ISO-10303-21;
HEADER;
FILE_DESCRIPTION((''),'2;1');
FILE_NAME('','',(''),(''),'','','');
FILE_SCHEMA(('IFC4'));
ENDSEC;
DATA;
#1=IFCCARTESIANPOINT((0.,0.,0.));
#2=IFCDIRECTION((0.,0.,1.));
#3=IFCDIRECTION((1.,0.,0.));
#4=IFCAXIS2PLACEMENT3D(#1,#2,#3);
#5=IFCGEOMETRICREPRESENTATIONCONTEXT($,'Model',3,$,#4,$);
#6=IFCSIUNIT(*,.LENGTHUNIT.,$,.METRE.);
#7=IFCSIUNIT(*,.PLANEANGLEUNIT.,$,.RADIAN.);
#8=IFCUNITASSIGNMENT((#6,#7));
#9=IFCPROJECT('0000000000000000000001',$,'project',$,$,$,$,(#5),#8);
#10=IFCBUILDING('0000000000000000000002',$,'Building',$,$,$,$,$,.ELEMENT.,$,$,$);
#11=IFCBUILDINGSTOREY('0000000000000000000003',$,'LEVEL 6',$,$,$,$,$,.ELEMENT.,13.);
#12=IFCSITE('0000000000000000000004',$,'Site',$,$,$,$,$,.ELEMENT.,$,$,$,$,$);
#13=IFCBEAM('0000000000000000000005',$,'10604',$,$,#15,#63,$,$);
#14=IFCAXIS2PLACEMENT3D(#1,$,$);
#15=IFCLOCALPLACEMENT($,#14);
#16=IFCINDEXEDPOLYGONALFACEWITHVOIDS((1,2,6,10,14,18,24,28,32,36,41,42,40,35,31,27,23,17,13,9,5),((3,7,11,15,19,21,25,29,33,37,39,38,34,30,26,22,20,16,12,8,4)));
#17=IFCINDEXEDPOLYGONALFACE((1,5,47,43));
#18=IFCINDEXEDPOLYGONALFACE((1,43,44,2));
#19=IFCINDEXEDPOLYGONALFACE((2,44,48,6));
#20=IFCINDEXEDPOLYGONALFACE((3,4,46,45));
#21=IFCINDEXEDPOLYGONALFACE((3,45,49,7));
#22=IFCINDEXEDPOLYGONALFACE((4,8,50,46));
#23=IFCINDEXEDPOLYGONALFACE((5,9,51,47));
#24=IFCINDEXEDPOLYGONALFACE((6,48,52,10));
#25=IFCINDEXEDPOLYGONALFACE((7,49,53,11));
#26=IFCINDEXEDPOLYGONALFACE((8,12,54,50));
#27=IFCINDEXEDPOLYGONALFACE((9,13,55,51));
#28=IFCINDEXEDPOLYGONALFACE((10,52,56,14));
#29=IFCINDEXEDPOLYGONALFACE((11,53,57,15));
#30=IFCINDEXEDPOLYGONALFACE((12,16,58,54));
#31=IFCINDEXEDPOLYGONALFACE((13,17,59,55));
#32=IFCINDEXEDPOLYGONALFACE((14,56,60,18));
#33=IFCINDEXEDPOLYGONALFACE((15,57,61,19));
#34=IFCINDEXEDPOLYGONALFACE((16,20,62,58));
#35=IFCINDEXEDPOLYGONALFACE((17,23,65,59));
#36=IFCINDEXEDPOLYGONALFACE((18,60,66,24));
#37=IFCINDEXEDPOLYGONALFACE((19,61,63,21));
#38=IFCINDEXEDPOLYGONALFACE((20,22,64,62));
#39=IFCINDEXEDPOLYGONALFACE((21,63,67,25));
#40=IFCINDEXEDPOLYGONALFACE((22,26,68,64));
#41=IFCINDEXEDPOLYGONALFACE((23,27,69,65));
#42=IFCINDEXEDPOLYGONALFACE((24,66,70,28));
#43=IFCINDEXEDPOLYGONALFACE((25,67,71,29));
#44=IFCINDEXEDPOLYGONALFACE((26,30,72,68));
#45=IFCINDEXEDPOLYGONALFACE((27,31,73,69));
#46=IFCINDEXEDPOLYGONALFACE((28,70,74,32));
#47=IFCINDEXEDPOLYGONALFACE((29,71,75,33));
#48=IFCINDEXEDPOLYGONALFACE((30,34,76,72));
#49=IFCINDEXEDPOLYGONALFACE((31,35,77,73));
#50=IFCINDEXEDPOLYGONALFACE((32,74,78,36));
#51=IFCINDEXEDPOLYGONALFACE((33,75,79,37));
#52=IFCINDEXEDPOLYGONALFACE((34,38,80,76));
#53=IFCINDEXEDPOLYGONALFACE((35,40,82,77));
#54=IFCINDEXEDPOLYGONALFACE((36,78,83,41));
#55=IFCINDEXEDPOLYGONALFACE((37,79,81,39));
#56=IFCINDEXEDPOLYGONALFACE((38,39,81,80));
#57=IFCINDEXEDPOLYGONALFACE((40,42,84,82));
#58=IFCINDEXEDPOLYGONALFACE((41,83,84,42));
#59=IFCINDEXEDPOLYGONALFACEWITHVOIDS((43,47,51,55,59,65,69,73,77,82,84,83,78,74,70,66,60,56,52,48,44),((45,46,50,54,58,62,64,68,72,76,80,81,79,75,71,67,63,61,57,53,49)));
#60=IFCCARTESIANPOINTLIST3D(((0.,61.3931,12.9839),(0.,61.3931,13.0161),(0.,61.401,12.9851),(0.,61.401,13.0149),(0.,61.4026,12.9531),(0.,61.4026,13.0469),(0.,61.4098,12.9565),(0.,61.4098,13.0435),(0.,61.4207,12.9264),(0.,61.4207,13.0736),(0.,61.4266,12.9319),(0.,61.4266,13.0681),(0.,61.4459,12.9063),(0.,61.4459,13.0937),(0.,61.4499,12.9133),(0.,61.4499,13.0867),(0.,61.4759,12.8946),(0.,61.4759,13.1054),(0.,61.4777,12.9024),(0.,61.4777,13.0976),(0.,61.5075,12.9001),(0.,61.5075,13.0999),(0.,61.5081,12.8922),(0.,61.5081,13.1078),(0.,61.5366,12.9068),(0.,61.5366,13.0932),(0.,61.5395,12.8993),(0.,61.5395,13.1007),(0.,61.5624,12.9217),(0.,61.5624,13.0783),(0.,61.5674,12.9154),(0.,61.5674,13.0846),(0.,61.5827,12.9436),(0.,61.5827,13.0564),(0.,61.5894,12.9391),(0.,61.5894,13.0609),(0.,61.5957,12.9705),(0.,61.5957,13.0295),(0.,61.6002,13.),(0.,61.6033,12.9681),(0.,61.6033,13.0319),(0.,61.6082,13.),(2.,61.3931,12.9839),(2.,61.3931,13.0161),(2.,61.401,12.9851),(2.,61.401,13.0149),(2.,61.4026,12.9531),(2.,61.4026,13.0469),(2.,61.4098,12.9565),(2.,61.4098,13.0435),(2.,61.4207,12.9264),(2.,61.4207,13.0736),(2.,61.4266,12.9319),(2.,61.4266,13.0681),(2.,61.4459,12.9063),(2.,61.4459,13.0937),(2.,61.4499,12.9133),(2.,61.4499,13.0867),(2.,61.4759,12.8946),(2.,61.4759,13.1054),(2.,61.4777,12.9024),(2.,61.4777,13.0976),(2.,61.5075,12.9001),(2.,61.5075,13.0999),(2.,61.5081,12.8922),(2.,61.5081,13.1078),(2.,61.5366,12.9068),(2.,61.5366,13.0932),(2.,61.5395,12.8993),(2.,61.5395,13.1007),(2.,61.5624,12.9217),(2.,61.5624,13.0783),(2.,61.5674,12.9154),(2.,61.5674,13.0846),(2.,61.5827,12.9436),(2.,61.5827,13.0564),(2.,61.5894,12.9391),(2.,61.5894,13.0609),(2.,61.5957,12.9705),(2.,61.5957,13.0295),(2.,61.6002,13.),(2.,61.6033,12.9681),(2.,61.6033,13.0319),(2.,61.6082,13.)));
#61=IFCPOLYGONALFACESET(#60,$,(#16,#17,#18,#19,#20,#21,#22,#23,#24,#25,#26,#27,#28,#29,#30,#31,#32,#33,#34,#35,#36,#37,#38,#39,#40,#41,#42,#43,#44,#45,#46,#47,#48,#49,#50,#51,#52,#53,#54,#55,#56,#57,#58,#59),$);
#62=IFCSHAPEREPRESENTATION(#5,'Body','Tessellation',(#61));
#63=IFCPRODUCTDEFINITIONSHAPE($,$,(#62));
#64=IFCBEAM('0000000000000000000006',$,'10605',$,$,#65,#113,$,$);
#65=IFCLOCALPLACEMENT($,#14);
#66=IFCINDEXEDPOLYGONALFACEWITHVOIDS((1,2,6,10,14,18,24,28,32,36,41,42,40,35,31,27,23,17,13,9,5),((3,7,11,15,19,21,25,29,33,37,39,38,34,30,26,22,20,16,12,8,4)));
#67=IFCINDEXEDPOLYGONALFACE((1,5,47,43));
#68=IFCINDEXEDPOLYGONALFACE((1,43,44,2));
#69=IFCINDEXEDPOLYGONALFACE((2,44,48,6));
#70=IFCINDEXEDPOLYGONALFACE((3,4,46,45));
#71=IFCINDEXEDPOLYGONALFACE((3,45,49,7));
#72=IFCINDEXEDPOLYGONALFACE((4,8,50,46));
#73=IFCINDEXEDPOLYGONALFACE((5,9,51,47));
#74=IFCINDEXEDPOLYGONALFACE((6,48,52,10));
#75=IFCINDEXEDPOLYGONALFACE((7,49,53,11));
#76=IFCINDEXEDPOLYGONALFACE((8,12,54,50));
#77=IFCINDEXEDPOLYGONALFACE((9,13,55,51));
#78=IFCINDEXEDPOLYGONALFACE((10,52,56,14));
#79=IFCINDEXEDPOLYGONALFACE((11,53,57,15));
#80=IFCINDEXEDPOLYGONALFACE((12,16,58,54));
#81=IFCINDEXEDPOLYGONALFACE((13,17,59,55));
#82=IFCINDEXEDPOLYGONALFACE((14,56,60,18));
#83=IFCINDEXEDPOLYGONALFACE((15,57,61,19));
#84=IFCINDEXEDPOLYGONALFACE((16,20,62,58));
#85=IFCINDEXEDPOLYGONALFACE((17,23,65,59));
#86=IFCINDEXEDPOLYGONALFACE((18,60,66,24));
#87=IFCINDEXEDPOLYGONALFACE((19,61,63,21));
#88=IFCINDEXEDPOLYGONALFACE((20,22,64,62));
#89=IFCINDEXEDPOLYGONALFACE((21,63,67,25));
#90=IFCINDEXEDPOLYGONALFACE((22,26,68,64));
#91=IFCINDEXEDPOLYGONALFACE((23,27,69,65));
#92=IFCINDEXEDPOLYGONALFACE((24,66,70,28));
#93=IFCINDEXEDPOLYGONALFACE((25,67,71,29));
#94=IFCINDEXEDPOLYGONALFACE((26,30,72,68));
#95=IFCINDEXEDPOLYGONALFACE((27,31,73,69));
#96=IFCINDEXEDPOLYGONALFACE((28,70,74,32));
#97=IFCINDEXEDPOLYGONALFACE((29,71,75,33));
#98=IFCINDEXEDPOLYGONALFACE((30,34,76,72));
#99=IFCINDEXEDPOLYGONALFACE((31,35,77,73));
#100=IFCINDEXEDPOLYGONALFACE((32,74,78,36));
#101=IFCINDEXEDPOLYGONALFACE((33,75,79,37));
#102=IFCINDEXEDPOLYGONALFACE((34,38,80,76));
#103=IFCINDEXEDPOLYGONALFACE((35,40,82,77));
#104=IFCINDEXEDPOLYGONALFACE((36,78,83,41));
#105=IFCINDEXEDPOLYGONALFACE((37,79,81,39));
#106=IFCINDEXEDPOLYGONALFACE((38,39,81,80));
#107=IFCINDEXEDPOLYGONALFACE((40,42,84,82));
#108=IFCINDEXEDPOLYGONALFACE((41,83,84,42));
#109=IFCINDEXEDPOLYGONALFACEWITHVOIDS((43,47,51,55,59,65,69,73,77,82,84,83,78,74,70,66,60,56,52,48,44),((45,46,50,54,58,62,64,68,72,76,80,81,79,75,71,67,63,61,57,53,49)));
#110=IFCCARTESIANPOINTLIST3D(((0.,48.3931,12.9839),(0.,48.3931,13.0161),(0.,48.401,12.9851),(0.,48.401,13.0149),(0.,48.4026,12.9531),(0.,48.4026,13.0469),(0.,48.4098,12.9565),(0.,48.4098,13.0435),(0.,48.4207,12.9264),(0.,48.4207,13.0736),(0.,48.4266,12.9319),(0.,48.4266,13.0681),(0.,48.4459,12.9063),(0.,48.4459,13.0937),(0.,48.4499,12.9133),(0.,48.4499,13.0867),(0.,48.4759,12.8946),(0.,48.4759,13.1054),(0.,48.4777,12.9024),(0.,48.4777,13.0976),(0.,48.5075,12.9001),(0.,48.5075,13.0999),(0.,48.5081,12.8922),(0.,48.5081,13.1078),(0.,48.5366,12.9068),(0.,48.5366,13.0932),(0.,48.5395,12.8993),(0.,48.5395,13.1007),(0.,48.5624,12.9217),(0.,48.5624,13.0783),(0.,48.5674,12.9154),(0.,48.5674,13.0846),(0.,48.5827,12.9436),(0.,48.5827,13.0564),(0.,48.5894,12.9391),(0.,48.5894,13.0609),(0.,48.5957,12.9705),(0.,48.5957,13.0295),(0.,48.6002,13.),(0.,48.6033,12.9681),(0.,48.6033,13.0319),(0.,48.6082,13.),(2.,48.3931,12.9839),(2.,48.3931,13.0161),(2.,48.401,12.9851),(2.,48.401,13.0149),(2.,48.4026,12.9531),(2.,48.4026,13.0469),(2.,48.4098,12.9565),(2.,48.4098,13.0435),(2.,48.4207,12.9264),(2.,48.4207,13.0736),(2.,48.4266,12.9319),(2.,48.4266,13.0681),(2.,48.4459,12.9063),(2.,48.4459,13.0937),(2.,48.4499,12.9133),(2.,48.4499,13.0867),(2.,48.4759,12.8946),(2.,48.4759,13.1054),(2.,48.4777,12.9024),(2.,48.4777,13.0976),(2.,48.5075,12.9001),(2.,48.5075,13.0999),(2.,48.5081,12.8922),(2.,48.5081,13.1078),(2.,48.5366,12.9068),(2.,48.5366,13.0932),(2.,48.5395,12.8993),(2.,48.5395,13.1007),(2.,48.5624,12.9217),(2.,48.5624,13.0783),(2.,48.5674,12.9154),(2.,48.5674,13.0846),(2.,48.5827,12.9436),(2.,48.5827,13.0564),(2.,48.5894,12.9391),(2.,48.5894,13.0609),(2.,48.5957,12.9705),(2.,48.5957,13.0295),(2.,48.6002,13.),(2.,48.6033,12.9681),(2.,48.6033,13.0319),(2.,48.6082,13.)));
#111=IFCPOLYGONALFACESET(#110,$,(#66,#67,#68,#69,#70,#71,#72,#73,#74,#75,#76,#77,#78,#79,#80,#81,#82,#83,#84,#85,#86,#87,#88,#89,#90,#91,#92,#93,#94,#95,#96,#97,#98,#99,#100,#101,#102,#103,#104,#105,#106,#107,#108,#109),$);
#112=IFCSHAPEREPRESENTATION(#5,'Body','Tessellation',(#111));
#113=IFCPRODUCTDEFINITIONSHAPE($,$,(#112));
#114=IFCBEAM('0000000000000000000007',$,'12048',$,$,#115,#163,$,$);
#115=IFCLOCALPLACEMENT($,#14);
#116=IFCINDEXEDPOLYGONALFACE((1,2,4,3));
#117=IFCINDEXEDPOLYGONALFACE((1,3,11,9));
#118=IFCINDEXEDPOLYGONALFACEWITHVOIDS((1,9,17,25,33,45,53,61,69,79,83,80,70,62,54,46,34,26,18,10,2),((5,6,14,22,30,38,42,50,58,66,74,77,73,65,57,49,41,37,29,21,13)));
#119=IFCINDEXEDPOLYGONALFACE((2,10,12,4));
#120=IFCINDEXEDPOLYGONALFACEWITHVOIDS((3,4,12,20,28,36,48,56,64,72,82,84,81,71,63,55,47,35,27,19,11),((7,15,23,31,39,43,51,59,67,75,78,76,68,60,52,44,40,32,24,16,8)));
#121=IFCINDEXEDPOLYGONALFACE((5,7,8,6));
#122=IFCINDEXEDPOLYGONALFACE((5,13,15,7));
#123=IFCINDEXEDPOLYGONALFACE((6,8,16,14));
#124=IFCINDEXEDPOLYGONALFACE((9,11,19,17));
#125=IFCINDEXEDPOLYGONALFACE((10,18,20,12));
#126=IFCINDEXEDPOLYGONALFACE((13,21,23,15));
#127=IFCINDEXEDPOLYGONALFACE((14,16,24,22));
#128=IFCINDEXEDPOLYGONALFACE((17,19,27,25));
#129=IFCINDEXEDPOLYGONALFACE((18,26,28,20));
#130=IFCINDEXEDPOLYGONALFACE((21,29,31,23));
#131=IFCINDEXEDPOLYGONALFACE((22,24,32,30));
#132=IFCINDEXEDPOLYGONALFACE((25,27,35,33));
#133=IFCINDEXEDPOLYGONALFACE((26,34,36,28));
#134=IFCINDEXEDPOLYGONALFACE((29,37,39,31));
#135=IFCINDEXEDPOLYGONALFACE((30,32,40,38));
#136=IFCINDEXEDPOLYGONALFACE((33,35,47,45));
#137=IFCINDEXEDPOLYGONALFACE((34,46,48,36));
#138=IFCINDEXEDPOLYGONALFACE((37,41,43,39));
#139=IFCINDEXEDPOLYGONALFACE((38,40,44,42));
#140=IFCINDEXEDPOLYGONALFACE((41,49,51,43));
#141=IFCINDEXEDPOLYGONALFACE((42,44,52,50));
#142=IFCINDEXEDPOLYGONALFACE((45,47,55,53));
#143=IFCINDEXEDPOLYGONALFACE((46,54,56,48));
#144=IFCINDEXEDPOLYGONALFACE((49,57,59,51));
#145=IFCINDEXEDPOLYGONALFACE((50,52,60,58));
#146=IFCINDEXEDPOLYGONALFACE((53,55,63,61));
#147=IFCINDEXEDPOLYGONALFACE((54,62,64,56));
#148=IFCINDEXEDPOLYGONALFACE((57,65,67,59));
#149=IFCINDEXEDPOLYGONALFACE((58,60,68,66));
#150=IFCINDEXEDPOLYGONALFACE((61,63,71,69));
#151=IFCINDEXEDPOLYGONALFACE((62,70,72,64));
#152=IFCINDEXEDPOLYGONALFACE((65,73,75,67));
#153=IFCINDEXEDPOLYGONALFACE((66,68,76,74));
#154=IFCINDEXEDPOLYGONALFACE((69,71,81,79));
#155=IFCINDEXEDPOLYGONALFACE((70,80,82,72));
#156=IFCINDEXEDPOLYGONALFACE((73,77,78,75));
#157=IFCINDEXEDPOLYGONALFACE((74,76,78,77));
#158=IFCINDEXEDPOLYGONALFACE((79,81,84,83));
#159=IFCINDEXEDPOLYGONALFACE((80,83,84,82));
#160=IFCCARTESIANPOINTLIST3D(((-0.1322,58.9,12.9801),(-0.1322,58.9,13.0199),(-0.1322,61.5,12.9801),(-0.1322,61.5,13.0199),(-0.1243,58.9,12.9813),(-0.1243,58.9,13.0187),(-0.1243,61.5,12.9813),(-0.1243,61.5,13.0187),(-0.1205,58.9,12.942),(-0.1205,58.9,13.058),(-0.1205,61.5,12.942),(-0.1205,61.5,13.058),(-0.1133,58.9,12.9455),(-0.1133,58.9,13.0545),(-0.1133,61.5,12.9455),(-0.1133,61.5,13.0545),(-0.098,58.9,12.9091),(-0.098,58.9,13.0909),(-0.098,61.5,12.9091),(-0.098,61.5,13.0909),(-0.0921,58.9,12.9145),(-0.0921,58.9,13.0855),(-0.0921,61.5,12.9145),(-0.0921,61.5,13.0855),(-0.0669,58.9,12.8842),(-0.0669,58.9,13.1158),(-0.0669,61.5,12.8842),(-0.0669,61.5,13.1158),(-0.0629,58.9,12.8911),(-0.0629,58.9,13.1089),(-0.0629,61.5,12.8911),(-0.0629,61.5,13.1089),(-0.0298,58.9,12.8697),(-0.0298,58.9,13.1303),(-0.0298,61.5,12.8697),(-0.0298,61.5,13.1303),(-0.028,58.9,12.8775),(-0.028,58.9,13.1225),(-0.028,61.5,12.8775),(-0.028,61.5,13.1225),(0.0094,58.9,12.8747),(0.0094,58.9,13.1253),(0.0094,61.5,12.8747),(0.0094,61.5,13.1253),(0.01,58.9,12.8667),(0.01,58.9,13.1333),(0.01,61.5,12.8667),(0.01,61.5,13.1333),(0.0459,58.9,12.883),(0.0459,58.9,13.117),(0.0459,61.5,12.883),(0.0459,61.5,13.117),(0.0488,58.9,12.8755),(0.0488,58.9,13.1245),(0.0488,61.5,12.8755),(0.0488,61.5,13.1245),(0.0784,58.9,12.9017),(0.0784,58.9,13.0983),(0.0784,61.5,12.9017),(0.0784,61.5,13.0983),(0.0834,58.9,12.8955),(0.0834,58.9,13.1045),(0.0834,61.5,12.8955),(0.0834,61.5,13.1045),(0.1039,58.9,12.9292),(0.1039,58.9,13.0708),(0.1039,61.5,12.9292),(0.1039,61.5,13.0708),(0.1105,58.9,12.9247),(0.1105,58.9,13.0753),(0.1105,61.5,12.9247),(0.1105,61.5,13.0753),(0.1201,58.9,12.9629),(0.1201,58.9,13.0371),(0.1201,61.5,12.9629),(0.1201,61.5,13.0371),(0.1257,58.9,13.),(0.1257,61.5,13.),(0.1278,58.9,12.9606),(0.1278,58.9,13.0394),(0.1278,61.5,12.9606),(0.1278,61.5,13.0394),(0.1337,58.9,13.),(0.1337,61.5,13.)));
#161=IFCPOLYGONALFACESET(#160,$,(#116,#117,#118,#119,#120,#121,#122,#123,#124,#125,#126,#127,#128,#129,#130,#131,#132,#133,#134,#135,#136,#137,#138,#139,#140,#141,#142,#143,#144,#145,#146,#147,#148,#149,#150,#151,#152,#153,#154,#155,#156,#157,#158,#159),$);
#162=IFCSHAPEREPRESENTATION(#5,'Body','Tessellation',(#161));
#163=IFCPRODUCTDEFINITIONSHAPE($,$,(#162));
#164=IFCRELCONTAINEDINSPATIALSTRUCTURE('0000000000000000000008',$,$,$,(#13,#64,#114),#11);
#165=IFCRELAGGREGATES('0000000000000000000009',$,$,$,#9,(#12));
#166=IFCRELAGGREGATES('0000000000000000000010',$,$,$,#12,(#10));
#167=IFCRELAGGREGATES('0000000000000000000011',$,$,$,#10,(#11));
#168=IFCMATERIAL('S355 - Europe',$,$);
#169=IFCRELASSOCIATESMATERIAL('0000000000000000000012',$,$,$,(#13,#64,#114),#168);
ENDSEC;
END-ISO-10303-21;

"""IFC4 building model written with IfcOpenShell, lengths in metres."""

from ifc_helpers import new_model, si_unit, frame, origin_with_axes, origin_2d_with_axis, place, context, project, spatial, hollow_circle, extrude, material, material_profile, profile_set, profile_usage, element, save


model = new_model("IFC4")

# Units and contexts
model_context = context("Model", 3, world=origin_with_axes())
ifc_project = project(units=[si_unit("LENGTHUNIT", "METRE"), si_unit("PLANEANGLEUNIT", "RADIAN")], contexts=[model_context])

# Site, building, storey
site = spatial("IfcSite", under=ifc_project, Name="Site", CompositionType="ELEMENT")
building = spatial("IfcBuilding", under=site, Name="Building", CompositionType="ELEMENT")
storey = spatial("IfcBuildingStorey", under=building, Name="LEVEL 6", CompositionType="ELEMENT", Elevation=13.0)

# Shared definitions
ifc_material = material(Name="S355 - Europe")

# Beams
ifc_material_profile_1 = material_profile(ifc_material, hollow_circle(Radius=0.1081, WallThickness=0.008, at=origin_2d_with_axis()))
ifc_profile_set_1 = profile_set([ifc_material_profile_1])
ifc_profile_usage_1 = profile_usage(ifc_profile_set_1, cardinal=10)
beam_1_placement = place(None, frame((0.0, 61.5, 13.0), z_axis=(1.0, 0.0, 0.0), x_axis=(0.0, 1.0, 0.0)))
element("IfcBeam", 1, at=beam_1_placement, inside=storey, material=ifc_profile_usage_1, Name="10604", context=model_context, shape_type="SweptSolid", body=[
    extrude(hollow_circle(Radius=0.1081, WallThickness=0.008, at=origin_2d_with_axis()), origin_with_axes(), (0.0, 0.0, 1.0), 2.0),
])
ifc_material_profile_2 = material_profile(ifc_material, hollow_circle(Radius=0.1081, WallThickness=0.008, at=origin_2d_with_axis()))
ifc_profile_set_2 = profile_set([ifc_material_profile_2])
ifc_profile_usage_2 = profile_usage(ifc_profile_set_2, cardinal=10)
beam_2_placement = place(None, frame((0.0, 48.5, 13.0), z_axis=(1.0, 0.0, 0.0), x_axis=(0.0, 1.0, 0.0)))
element("IfcBeam", 2, at=beam_2_placement, inside=storey, material=ifc_profile_usage_2, Name="10605", context=model_context, shape_type="SweptSolid", body=[
    extrude(hollow_circle(Radius=0.1081, WallThickness=0.008, at=origin_2d_with_axis()), origin_with_axes(), (0.0, 0.0, 1.0), 2.0),
])
ifc_material_profile_3 = material_profile(ifc_material, hollow_circle(Radius=0.1337, WallThickness=0.008, at=origin_2d_with_axis()))
ifc_profile_set_3 = profile_set([ifc_material_profile_3])
ifc_profile_usage_3 = profile_usage(ifc_profile_set_3, cardinal=10)
beam_3_placement = place(None, frame((0.0, 61.5, 13.0), z_axis=(0.0, -1.0, 0.0), x_axis=(1.0, 0.0, 0.0)))
element("IfcBeam", 3, at=beam_3_placement, inside=storey, material=ifc_profile_usage_3, Name="12048", context=model_context, shape_type="SweptSolid", body=[
    extrude(hollow_circle(Radius=0.1337, WallThickness=0.008, at=origin_2d_with_axis()), origin_with_axes(), (0.0, 0.0, 1.0), 2.6),
])

save(model, "model.ifc")
